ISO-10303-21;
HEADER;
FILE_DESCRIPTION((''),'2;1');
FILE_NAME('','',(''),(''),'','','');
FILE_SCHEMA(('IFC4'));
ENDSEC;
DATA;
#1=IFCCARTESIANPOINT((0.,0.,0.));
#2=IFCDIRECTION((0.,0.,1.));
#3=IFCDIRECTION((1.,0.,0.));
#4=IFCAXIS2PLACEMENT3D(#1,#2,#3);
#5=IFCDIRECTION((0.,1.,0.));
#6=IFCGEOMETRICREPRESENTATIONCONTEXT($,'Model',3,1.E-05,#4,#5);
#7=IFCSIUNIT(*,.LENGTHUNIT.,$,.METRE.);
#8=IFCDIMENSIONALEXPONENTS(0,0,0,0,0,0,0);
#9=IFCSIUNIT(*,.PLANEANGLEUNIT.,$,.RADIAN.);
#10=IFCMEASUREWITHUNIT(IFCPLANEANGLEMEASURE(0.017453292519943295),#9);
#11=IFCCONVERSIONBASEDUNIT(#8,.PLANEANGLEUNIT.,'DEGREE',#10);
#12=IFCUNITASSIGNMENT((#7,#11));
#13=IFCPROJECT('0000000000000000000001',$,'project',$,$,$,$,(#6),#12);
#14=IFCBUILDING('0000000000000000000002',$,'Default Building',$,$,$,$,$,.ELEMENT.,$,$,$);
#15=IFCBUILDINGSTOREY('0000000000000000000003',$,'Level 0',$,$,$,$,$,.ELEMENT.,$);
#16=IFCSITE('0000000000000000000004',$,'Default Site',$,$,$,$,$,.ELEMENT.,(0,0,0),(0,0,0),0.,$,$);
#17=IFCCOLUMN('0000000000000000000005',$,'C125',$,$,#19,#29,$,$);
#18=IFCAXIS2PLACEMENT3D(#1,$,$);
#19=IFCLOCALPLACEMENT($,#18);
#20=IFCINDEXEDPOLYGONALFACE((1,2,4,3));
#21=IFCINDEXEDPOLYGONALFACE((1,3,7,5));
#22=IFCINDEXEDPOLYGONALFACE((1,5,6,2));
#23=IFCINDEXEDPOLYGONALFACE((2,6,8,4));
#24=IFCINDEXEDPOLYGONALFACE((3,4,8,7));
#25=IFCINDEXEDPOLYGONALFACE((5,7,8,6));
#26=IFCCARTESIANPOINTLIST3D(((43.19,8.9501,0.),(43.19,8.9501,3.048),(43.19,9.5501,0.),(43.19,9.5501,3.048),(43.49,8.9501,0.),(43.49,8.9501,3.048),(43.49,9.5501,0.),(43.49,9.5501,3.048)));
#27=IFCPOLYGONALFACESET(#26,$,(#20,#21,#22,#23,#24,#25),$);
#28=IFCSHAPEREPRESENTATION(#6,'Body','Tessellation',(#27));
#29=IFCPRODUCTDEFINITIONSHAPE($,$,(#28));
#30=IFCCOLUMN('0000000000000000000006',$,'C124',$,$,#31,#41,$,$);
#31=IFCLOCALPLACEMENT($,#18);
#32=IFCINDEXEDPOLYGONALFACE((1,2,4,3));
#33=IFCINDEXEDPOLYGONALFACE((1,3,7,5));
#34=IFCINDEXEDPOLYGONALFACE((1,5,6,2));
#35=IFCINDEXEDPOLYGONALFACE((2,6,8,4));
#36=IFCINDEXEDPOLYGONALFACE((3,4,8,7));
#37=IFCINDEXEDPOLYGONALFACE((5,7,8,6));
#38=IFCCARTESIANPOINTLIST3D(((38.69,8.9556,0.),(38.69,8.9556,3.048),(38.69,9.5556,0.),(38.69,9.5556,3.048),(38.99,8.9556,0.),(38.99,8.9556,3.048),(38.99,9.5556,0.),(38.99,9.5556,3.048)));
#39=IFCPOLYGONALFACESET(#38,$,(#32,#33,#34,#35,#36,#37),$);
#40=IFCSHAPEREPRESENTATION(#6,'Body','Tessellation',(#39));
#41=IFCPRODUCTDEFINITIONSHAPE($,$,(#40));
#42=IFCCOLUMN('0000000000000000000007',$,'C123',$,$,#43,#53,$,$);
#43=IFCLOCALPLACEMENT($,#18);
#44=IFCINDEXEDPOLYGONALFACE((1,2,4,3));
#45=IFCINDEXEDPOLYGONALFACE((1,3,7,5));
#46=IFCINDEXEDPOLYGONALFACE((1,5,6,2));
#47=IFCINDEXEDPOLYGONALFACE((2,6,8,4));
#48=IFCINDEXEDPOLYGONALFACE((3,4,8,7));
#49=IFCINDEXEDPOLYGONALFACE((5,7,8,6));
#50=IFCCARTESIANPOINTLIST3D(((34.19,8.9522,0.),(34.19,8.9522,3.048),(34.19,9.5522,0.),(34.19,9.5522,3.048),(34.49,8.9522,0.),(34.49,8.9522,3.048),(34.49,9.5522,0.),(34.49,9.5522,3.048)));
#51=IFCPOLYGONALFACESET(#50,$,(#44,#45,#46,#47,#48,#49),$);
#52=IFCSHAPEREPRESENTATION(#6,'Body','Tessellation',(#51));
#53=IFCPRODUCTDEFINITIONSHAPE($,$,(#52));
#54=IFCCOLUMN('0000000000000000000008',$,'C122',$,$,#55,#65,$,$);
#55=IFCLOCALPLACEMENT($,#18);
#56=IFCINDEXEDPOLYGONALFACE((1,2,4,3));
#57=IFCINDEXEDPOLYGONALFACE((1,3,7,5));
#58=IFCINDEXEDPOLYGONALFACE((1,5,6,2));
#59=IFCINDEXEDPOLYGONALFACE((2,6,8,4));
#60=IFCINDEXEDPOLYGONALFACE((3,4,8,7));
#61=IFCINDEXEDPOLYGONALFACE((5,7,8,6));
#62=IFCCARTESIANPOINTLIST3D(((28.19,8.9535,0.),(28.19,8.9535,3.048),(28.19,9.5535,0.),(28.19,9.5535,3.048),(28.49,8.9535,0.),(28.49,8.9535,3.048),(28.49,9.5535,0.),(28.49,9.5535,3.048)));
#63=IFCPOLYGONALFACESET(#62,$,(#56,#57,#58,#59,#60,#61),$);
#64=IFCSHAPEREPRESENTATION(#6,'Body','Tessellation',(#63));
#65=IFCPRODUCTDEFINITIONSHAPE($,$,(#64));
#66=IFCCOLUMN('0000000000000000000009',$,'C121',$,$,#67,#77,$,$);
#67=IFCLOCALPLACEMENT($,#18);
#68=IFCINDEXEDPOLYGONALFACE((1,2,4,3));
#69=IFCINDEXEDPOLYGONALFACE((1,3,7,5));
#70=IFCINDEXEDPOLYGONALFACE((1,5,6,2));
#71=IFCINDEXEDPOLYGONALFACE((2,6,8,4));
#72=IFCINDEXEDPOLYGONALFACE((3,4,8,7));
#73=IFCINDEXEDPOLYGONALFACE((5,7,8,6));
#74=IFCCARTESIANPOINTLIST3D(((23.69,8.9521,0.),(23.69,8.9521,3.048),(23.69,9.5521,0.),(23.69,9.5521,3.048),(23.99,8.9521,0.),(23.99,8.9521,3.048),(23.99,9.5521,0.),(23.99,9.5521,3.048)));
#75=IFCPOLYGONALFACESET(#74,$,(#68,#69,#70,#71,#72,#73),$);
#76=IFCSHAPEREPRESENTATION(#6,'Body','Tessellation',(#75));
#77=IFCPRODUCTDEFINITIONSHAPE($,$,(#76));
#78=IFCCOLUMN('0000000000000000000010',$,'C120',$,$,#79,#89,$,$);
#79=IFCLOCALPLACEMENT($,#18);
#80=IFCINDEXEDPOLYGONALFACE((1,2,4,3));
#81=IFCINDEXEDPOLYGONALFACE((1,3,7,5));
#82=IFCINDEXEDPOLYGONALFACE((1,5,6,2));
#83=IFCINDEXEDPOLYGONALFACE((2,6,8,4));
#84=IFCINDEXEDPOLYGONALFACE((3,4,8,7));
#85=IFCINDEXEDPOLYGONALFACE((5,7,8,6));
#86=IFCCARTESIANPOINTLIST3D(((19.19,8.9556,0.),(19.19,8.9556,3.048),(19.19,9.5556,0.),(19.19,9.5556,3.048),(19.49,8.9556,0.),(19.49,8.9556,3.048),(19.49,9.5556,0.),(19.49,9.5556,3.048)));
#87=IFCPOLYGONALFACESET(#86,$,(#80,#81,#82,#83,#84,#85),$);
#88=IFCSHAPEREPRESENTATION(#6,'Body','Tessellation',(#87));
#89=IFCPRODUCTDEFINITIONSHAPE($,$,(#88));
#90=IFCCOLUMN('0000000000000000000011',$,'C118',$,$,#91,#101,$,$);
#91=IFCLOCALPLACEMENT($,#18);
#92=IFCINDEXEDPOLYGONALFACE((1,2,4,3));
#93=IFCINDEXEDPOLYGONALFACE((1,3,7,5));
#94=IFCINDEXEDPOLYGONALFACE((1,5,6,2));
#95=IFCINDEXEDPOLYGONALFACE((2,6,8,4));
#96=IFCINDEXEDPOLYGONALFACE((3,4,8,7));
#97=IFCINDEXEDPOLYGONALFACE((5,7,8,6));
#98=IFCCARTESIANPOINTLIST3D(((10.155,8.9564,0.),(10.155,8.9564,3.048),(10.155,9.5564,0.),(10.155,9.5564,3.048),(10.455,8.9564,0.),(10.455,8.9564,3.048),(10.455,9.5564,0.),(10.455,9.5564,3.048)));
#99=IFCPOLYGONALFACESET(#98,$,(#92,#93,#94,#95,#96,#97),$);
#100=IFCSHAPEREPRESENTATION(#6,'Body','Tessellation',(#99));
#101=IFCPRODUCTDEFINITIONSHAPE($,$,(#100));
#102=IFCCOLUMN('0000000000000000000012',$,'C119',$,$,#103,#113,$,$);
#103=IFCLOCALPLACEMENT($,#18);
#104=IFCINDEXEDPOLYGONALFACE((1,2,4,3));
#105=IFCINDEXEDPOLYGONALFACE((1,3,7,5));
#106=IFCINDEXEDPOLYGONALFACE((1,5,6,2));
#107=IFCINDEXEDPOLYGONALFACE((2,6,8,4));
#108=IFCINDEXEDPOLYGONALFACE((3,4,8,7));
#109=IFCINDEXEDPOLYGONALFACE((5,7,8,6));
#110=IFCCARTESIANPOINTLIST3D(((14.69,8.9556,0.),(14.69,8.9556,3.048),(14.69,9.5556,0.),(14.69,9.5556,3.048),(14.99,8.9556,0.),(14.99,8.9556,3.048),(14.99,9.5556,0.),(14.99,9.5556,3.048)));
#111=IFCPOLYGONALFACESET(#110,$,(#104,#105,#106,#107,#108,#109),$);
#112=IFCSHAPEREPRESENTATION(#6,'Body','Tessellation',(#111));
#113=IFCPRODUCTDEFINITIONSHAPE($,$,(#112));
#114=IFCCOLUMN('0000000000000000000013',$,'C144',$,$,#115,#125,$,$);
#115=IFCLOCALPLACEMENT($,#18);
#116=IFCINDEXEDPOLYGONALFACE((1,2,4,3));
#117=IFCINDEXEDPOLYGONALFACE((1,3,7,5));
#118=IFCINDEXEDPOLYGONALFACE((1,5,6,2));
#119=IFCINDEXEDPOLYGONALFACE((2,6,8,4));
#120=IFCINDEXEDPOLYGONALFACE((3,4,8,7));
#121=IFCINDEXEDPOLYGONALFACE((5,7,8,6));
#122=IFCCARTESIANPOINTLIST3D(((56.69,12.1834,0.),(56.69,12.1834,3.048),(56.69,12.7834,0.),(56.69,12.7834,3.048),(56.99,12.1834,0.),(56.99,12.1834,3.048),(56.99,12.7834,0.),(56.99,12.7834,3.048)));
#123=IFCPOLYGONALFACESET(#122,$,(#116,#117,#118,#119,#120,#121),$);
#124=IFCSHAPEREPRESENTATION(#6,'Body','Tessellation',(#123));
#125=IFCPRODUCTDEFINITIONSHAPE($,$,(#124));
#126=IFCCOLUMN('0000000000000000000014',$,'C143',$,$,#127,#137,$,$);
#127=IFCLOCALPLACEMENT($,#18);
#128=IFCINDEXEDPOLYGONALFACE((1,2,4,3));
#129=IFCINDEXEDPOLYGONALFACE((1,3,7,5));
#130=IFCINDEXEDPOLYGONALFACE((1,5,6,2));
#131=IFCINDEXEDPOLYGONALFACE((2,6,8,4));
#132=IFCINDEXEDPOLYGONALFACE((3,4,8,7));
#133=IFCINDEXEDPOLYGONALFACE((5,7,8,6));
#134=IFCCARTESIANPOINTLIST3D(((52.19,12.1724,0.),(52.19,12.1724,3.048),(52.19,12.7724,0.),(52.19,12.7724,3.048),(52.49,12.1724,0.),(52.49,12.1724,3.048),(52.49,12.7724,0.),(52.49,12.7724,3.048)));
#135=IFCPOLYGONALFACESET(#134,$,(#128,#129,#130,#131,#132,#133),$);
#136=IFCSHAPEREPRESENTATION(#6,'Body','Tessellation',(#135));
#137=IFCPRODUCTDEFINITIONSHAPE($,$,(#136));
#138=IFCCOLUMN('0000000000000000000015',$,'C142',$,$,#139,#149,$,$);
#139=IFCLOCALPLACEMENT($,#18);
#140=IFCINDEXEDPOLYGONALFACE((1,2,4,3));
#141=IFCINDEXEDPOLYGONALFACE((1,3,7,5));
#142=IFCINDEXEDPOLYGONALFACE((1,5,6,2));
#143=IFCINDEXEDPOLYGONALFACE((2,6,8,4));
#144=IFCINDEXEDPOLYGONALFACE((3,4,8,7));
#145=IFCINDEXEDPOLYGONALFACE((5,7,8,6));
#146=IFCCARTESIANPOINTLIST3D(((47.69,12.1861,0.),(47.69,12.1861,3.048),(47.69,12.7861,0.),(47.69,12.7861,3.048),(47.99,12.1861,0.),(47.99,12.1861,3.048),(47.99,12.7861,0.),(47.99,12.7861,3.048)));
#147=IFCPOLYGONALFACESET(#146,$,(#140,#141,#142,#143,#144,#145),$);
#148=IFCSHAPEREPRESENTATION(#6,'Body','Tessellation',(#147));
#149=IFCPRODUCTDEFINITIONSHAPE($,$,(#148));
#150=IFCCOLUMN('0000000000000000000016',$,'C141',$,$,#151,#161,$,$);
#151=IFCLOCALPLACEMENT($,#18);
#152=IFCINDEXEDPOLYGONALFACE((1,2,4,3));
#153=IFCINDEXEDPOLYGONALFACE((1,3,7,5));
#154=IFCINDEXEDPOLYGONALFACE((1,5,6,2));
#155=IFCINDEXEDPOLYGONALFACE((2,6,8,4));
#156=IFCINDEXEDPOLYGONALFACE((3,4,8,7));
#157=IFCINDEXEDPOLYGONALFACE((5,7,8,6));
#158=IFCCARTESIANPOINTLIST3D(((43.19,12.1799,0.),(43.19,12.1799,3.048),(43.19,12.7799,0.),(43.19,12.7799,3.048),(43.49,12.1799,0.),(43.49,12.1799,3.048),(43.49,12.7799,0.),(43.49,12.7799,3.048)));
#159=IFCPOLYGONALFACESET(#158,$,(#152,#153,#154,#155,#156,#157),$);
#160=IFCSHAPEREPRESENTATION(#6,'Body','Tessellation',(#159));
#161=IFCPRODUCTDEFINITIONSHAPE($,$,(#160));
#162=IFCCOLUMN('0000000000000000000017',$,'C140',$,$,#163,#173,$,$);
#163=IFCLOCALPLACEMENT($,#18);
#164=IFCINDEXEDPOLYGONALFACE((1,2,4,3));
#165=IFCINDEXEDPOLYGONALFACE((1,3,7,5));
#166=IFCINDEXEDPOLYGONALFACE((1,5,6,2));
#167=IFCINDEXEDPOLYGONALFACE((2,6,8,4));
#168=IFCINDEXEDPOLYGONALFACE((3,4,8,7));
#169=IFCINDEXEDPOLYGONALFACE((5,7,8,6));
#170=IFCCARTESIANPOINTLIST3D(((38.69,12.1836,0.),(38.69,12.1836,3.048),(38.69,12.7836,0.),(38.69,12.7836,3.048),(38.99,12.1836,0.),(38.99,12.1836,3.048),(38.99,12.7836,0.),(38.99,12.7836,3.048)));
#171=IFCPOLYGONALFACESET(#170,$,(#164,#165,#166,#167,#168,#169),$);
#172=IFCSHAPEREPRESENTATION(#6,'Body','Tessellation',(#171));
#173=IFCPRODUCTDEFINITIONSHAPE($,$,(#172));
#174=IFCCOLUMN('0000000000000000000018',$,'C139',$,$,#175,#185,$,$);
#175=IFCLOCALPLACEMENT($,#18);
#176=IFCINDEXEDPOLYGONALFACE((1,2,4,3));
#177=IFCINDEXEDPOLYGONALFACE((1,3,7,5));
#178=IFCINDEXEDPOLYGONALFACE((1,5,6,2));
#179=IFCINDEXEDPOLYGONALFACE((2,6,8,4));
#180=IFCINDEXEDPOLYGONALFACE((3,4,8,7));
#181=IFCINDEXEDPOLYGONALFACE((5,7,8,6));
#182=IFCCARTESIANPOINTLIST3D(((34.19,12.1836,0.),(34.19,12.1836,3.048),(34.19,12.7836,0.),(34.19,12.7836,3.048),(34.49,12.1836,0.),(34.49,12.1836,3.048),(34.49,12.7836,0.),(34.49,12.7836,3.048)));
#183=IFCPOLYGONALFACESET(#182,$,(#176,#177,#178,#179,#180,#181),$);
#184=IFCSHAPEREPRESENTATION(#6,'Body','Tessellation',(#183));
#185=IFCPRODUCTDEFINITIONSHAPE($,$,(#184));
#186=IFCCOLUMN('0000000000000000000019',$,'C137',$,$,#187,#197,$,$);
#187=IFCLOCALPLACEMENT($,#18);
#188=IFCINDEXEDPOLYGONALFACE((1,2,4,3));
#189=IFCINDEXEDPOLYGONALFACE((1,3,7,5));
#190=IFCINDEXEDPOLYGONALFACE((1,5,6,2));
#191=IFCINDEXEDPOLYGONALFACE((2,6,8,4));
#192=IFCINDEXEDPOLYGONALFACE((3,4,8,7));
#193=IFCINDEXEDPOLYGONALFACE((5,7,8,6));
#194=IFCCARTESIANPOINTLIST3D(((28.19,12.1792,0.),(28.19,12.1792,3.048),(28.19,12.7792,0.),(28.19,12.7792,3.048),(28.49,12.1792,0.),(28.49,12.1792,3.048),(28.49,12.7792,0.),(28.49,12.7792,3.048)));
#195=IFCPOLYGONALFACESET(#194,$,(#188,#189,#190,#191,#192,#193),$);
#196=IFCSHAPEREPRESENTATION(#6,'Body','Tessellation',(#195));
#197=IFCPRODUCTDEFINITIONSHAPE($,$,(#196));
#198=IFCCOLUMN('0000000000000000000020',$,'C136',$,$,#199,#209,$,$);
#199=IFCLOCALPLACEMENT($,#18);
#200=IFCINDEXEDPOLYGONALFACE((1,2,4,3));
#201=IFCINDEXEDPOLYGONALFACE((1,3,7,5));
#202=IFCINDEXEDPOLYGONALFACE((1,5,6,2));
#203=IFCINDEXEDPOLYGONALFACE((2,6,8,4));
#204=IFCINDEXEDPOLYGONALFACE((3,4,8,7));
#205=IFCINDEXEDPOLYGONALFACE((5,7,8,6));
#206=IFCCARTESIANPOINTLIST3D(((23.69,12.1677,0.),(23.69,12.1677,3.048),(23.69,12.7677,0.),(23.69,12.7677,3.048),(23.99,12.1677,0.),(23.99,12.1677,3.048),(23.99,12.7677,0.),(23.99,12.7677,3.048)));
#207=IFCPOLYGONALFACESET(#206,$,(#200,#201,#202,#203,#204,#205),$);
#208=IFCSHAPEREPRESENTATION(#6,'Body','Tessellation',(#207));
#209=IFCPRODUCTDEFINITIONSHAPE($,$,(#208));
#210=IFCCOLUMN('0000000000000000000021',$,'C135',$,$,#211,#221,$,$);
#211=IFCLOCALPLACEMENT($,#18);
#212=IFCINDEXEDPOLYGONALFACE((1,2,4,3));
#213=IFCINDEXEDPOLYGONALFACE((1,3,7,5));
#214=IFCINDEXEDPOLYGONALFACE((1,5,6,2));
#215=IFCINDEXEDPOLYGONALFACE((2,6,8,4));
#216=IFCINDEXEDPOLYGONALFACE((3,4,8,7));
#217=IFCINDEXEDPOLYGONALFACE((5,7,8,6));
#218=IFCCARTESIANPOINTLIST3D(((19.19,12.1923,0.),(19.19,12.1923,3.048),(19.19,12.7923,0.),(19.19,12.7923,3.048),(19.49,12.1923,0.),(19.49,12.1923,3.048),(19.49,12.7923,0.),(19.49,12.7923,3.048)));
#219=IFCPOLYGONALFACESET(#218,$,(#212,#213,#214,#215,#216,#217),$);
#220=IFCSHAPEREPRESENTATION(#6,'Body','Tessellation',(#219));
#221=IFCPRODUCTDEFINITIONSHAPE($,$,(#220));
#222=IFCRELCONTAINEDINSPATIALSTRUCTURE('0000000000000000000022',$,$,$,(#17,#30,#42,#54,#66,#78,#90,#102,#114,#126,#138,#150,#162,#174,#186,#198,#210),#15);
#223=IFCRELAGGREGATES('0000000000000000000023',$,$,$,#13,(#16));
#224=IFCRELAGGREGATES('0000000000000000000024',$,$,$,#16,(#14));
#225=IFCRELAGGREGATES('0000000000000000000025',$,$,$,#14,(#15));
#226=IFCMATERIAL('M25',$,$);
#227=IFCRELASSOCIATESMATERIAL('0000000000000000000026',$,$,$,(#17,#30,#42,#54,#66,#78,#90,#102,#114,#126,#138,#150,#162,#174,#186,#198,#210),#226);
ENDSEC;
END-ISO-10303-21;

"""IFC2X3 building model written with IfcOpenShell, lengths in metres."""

from ifc_helpers import new_model, entity, si_unit, converted_unit, direction, frame, frame_2d, origin_with_axes, place, context, project, spatial, rectangle, extrude, material, element, save


model = new_model("IFC2X3")

# Units and contexts
model_context = context("Model", 3, precision=1e-05, world=origin_with_axes(), true_north=direction((0.0, 1.0, 0.0)))
ifc_project = project(units=[si_unit("LENGTHUNIT", "METRE"), converted_unit("PLANEANGLEUNIT", "DEGREE", entity("IfcPlaneAngleMeasure", 0.017453292519943295), si_unit("PLANEANGLEUNIT", "RADIAN"), dimensions=[0, 0, 0, 0, 0, 0, 0])], contexts=[model_context])

# Site, building, storey
site = spatial("IfcSite", under=ifc_project, Name="Default Site", CompositionType="ELEMENT", RefLatitude=(0, 0, 0), RefLongitude=(0, 0, 0), RefElevation=0.0)
building = spatial("IfcBuilding", under=site, Name="Default Building", CompositionType="ELEMENT")
storey = spatial("IfcBuildingStorey", under=building, Name="Level 0", CompositionType="ELEMENT")

# Columns
ifc_material = material(Name="M25")
placement = place(None, origin_with_axes())
element("IfcColumn", 1, at=placement, inside=storey, material=ifc_material, Name="C125", context=model_context, shape_type="SweptSolid", body=[
    extrude(rectangle(XDim=0.3, YDim=0.6, at=frame_2d((0.0, 0.0), x_axis=(1.0, 0.0, 0.0))), frame((43.34, 9.2501, 0.0), z_axis=(0.0, 0.0, 1.0), x_axis=(1.0, 0.0, 0.0)), (0.0, 0.0, 1.0), 3.048),
])
element("IfcColumn", 2, at=placement, inside=storey, material=ifc_material, Name="C124", context=model_context, shape_type="SweptSolid", body=[
    extrude(rectangle(XDim=0.3, YDim=0.6, at=frame_2d((0.0, 0.0), x_axis=(1.0, 0.0, 0.0))), frame((38.84, 9.2556, 0.0), z_axis=(0.0, 0.0, 1.0), x_axis=(1.0, 0.0, 0.0)), (0.0, 0.0, 1.0), 3.048),
])
element("IfcColumn", 3, at=placement, inside=storey, material=ifc_material, Name="C123", context=model_context, shape_type="SweptSolid", body=[
    extrude(rectangle(XDim=0.3, YDim=0.6, at=frame_2d((0.0, 0.0), x_axis=(1.0, 0.0, 0.0))), frame((34.34, 9.2522, 0.0), z_axis=(0.0, 0.0, 1.0), x_axis=(1.0, 0.0, 0.0)), (0.0, 0.0, 1.0), 3.048),
])
element("IfcColumn", 4, at=placement, inside=storey, material=ifc_material, Name="C122", context=model_context, shape_type="SweptSolid", body=[
    extrude(rectangle(XDim=0.3, YDim=0.6, at=frame_2d((0.0, 0.0), x_axis=(1.0, 0.0, 0.0))), frame((28.34, 9.2535, 0.0), z_axis=(0.0, 0.0, 1.0), x_axis=(1.0, 0.0, 0.0)), (0.0, 0.0, 1.0), 3.048),
])
element("IfcColumn", 5, at=placement, inside=storey, material=ifc_material, Name="C121", context=model_context, shape_type="SweptSolid", body=[
    extrude(rectangle(XDim=0.3, YDim=0.6, at=frame_2d((0.0, 0.0), x_axis=(1.0, 0.0, 0.0))), frame((23.84, 9.2521, 0.0), z_axis=(0.0, 0.0, 1.0), x_axis=(1.0, 0.0, 0.0)), (0.0, 0.0, 1.0), 3.048),
])
element("IfcColumn", 6, at=placement, inside=storey, material=ifc_material, Name="C120", context=model_context, shape_type="SweptSolid", body=[
    extrude(rectangle(XDim=0.3, YDim=0.6, at=frame_2d((0.0, 0.0), x_axis=(1.0, 0.0, 0.0))), frame((19.34, 9.2556, 0.0), z_axis=(0.0, 0.0, 1.0), x_axis=(1.0, 0.0, 0.0)), (0.0, 0.0, 1.0), 3.048),
])
element("IfcColumn", 7, at=placement, inside=storey, material=ifc_material, Name="C118", context=model_context, shape_type="SweptSolid", body=[
    extrude(rectangle(XDim=0.3, YDim=0.6, at=frame_2d((0.0, 0.0), x_axis=(1.0, 0.0, 0.0))), frame((10.305, 9.2564, 0.0), z_axis=(0.0, 0.0, 1.0), x_axis=(1.0, 0.0, 0.0)), (0.0, 0.0, 1.0), 3.048),
])
element("IfcColumn", 8, at=placement, inside=storey, material=ifc_material, Name="C119", context=model_context, shape_type="SweptSolid", body=[
    extrude(rectangle(XDim=0.3, YDim=0.6, at=frame_2d((0.0, 0.0), x_axis=(1.0, 0.0, 0.0))), frame((14.84, 9.2556, 0.0), z_axis=(0.0, 0.0, 1.0), x_axis=(1.0, 0.0, 0.0)), (0.0, 0.0, 1.0), 3.048),
])
element("IfcColumn", 9, at=placement, inside=storey, material=ifc_material, Name="C144", context=model_context, shape_type="SweptSolid", body=[
    extrude(rectangle(XDim=0.3, YDim=0.6, at=frame_2d((0.0, 0.0), x_axis=(1.0, 0.0, 0.0))), frame((56.84, 12.4834, 0.0), z_axis=(0.0, 0.0, 1.0), x_axis=(1.0, 0.0, 0.0)), (0.0, 0.0, 1.0), 3.048),
])
element("IfcColumn", 10, at=placement, inside=storey, material=ifc_material, Name="C143", context=model_context, shape_type="SweptSolid", body=[
    extrude(rectangle(XDim=0.3, YDim=0.6, at=frame_2d((0.0, 0.0), x_axis=(1.0, 0.0, 0.0))), frame((52.34, 12.4724, 0.0), z_axis=(0.0, 0.0, 1.0), x_axis=(1.0, 0.0, 0.0)), (0.0, 0.0, 1.0), 3.048),
])
element("IfcColumn", 11, at=placement, inside=storey, material=ifc_material, Name="C142", context=model_context, shape_type="SweptSolid", body=[
    extrude(rectangle(XDim=0.3, YDim=0.6, at=frame_2d((0.0, 0.0), x_axis=(1.0, 0.0, 0.0))), frame((47.84, 12.4861, 0.0), z_axis=(0.0, 0.0, 1.0), x_axis=(1.0, 0.0, 0.0)), (0.0, 0.0, 1.0), 3.048),
])
element("IfcColumn", 12, at=placement, inside=storey, material=ifc_material, Name="C141", context=model_context, shape_type="SweptSolid", body=[
    extrude(rectangle(XDim=0.3, YDim=0.6, at=frame_2d((0.0, 0.0), x_axis=(1.0, 0.0, 0.0))), frame((43.34, 12.4799, 0.0), z_axis=(0.0, 0.0, 1.0), x_axis=(1.0, 0.0, 0.0)), (0.0, 0.0, 1.0), 3.048),
])
element("IfcColumn", 13, at=placement, inside=storey, material=ifc_material, Name="C140", context=model_context, shape_type="SweptSolid", body=[
    extrude(rectangle(XDim=0.3, YDim=0.6, at=frame_2d((0.0, 0.0), x_axis=(1.0, 0.0, 0.0))), frame((38.84, 12.4836, 0.0), z_axis=(0.0, 0.0, 1.0), x_axis=(1.0, 0.0, 0.0)), (0.0, 0.0, 1.0), 3.048),
])
element("IfcColumn", 14, at=placement, inside=storey, material=ifc_material, Name="C139", context=model_context, shape_type="SweptSolid", body=[
    extrude(rectangle(XDim=0.3, YDim=0.6, at=frame_2d((0.0, 0.0), x_axis=(1.0, 0.0, 0.0))), frame((34.34, 12.4836, 0.0), z_axis=(0.0, 0.0, 1.0), x_axis=(1.0, 0.0, 0.0)), (0.0, 0.0, 1.0), 3.048),
])
element("IfcColumn", 15, at=placement, inside=storey, material=ifc_material, Name="C137", context=model_context, shape_type="SweptSolid", body=[
    extrude(rectangle(XDim=0.3, YDim=0.6, at=frame_2d((0.0, 0.0), x_axis=(1.0, 0.0, 0.0))), frame((28.34, 12.4792, 0.0), z_axis=(0.0, 0.0, 1.0), x_axis=(1.0, 0.0, 0.0)), (0.0, 0.0, 1.0), 3.048),
])
element("IfcColumn", 16, at=placement, inside=storey, material=ifc_material, Name="C136", context=model_context, shape_type="SweptSolid", body=[
    extrude(rectangle(XDim=0.3, YDim=0.6, at=frame_2d((0.0, 0.0), x_axis=(1.0, 0.0, 0.0))), frame((23.84, 12.4677, 0.0), z_axis=(0.0, 0.0, 1.0), x_axis=(1.0, 0.0, 0.0)), (0.0, 0.0, 1.0), 3.048),
])
element("IfcColumn", 17, at=placement, inside=storey, material=ifc_material, Name="C135", context=model_context, shape_type="SweptSolid", body=[
    extrude(rectangle(XDim=0.3, YDim=0.6, at=frame_2d((0.0, 0.0), x_axis=(1.0, 0.0, 0.0))), frame((19.34, 12.4923, 0.0), z_axis=(0.0, 0.0, 1.0), x_axis=(1.0, 0.0, 0.0)), (0.0, 0.0, 1.0), 3.048),
])

save(model, "model.ifc")
